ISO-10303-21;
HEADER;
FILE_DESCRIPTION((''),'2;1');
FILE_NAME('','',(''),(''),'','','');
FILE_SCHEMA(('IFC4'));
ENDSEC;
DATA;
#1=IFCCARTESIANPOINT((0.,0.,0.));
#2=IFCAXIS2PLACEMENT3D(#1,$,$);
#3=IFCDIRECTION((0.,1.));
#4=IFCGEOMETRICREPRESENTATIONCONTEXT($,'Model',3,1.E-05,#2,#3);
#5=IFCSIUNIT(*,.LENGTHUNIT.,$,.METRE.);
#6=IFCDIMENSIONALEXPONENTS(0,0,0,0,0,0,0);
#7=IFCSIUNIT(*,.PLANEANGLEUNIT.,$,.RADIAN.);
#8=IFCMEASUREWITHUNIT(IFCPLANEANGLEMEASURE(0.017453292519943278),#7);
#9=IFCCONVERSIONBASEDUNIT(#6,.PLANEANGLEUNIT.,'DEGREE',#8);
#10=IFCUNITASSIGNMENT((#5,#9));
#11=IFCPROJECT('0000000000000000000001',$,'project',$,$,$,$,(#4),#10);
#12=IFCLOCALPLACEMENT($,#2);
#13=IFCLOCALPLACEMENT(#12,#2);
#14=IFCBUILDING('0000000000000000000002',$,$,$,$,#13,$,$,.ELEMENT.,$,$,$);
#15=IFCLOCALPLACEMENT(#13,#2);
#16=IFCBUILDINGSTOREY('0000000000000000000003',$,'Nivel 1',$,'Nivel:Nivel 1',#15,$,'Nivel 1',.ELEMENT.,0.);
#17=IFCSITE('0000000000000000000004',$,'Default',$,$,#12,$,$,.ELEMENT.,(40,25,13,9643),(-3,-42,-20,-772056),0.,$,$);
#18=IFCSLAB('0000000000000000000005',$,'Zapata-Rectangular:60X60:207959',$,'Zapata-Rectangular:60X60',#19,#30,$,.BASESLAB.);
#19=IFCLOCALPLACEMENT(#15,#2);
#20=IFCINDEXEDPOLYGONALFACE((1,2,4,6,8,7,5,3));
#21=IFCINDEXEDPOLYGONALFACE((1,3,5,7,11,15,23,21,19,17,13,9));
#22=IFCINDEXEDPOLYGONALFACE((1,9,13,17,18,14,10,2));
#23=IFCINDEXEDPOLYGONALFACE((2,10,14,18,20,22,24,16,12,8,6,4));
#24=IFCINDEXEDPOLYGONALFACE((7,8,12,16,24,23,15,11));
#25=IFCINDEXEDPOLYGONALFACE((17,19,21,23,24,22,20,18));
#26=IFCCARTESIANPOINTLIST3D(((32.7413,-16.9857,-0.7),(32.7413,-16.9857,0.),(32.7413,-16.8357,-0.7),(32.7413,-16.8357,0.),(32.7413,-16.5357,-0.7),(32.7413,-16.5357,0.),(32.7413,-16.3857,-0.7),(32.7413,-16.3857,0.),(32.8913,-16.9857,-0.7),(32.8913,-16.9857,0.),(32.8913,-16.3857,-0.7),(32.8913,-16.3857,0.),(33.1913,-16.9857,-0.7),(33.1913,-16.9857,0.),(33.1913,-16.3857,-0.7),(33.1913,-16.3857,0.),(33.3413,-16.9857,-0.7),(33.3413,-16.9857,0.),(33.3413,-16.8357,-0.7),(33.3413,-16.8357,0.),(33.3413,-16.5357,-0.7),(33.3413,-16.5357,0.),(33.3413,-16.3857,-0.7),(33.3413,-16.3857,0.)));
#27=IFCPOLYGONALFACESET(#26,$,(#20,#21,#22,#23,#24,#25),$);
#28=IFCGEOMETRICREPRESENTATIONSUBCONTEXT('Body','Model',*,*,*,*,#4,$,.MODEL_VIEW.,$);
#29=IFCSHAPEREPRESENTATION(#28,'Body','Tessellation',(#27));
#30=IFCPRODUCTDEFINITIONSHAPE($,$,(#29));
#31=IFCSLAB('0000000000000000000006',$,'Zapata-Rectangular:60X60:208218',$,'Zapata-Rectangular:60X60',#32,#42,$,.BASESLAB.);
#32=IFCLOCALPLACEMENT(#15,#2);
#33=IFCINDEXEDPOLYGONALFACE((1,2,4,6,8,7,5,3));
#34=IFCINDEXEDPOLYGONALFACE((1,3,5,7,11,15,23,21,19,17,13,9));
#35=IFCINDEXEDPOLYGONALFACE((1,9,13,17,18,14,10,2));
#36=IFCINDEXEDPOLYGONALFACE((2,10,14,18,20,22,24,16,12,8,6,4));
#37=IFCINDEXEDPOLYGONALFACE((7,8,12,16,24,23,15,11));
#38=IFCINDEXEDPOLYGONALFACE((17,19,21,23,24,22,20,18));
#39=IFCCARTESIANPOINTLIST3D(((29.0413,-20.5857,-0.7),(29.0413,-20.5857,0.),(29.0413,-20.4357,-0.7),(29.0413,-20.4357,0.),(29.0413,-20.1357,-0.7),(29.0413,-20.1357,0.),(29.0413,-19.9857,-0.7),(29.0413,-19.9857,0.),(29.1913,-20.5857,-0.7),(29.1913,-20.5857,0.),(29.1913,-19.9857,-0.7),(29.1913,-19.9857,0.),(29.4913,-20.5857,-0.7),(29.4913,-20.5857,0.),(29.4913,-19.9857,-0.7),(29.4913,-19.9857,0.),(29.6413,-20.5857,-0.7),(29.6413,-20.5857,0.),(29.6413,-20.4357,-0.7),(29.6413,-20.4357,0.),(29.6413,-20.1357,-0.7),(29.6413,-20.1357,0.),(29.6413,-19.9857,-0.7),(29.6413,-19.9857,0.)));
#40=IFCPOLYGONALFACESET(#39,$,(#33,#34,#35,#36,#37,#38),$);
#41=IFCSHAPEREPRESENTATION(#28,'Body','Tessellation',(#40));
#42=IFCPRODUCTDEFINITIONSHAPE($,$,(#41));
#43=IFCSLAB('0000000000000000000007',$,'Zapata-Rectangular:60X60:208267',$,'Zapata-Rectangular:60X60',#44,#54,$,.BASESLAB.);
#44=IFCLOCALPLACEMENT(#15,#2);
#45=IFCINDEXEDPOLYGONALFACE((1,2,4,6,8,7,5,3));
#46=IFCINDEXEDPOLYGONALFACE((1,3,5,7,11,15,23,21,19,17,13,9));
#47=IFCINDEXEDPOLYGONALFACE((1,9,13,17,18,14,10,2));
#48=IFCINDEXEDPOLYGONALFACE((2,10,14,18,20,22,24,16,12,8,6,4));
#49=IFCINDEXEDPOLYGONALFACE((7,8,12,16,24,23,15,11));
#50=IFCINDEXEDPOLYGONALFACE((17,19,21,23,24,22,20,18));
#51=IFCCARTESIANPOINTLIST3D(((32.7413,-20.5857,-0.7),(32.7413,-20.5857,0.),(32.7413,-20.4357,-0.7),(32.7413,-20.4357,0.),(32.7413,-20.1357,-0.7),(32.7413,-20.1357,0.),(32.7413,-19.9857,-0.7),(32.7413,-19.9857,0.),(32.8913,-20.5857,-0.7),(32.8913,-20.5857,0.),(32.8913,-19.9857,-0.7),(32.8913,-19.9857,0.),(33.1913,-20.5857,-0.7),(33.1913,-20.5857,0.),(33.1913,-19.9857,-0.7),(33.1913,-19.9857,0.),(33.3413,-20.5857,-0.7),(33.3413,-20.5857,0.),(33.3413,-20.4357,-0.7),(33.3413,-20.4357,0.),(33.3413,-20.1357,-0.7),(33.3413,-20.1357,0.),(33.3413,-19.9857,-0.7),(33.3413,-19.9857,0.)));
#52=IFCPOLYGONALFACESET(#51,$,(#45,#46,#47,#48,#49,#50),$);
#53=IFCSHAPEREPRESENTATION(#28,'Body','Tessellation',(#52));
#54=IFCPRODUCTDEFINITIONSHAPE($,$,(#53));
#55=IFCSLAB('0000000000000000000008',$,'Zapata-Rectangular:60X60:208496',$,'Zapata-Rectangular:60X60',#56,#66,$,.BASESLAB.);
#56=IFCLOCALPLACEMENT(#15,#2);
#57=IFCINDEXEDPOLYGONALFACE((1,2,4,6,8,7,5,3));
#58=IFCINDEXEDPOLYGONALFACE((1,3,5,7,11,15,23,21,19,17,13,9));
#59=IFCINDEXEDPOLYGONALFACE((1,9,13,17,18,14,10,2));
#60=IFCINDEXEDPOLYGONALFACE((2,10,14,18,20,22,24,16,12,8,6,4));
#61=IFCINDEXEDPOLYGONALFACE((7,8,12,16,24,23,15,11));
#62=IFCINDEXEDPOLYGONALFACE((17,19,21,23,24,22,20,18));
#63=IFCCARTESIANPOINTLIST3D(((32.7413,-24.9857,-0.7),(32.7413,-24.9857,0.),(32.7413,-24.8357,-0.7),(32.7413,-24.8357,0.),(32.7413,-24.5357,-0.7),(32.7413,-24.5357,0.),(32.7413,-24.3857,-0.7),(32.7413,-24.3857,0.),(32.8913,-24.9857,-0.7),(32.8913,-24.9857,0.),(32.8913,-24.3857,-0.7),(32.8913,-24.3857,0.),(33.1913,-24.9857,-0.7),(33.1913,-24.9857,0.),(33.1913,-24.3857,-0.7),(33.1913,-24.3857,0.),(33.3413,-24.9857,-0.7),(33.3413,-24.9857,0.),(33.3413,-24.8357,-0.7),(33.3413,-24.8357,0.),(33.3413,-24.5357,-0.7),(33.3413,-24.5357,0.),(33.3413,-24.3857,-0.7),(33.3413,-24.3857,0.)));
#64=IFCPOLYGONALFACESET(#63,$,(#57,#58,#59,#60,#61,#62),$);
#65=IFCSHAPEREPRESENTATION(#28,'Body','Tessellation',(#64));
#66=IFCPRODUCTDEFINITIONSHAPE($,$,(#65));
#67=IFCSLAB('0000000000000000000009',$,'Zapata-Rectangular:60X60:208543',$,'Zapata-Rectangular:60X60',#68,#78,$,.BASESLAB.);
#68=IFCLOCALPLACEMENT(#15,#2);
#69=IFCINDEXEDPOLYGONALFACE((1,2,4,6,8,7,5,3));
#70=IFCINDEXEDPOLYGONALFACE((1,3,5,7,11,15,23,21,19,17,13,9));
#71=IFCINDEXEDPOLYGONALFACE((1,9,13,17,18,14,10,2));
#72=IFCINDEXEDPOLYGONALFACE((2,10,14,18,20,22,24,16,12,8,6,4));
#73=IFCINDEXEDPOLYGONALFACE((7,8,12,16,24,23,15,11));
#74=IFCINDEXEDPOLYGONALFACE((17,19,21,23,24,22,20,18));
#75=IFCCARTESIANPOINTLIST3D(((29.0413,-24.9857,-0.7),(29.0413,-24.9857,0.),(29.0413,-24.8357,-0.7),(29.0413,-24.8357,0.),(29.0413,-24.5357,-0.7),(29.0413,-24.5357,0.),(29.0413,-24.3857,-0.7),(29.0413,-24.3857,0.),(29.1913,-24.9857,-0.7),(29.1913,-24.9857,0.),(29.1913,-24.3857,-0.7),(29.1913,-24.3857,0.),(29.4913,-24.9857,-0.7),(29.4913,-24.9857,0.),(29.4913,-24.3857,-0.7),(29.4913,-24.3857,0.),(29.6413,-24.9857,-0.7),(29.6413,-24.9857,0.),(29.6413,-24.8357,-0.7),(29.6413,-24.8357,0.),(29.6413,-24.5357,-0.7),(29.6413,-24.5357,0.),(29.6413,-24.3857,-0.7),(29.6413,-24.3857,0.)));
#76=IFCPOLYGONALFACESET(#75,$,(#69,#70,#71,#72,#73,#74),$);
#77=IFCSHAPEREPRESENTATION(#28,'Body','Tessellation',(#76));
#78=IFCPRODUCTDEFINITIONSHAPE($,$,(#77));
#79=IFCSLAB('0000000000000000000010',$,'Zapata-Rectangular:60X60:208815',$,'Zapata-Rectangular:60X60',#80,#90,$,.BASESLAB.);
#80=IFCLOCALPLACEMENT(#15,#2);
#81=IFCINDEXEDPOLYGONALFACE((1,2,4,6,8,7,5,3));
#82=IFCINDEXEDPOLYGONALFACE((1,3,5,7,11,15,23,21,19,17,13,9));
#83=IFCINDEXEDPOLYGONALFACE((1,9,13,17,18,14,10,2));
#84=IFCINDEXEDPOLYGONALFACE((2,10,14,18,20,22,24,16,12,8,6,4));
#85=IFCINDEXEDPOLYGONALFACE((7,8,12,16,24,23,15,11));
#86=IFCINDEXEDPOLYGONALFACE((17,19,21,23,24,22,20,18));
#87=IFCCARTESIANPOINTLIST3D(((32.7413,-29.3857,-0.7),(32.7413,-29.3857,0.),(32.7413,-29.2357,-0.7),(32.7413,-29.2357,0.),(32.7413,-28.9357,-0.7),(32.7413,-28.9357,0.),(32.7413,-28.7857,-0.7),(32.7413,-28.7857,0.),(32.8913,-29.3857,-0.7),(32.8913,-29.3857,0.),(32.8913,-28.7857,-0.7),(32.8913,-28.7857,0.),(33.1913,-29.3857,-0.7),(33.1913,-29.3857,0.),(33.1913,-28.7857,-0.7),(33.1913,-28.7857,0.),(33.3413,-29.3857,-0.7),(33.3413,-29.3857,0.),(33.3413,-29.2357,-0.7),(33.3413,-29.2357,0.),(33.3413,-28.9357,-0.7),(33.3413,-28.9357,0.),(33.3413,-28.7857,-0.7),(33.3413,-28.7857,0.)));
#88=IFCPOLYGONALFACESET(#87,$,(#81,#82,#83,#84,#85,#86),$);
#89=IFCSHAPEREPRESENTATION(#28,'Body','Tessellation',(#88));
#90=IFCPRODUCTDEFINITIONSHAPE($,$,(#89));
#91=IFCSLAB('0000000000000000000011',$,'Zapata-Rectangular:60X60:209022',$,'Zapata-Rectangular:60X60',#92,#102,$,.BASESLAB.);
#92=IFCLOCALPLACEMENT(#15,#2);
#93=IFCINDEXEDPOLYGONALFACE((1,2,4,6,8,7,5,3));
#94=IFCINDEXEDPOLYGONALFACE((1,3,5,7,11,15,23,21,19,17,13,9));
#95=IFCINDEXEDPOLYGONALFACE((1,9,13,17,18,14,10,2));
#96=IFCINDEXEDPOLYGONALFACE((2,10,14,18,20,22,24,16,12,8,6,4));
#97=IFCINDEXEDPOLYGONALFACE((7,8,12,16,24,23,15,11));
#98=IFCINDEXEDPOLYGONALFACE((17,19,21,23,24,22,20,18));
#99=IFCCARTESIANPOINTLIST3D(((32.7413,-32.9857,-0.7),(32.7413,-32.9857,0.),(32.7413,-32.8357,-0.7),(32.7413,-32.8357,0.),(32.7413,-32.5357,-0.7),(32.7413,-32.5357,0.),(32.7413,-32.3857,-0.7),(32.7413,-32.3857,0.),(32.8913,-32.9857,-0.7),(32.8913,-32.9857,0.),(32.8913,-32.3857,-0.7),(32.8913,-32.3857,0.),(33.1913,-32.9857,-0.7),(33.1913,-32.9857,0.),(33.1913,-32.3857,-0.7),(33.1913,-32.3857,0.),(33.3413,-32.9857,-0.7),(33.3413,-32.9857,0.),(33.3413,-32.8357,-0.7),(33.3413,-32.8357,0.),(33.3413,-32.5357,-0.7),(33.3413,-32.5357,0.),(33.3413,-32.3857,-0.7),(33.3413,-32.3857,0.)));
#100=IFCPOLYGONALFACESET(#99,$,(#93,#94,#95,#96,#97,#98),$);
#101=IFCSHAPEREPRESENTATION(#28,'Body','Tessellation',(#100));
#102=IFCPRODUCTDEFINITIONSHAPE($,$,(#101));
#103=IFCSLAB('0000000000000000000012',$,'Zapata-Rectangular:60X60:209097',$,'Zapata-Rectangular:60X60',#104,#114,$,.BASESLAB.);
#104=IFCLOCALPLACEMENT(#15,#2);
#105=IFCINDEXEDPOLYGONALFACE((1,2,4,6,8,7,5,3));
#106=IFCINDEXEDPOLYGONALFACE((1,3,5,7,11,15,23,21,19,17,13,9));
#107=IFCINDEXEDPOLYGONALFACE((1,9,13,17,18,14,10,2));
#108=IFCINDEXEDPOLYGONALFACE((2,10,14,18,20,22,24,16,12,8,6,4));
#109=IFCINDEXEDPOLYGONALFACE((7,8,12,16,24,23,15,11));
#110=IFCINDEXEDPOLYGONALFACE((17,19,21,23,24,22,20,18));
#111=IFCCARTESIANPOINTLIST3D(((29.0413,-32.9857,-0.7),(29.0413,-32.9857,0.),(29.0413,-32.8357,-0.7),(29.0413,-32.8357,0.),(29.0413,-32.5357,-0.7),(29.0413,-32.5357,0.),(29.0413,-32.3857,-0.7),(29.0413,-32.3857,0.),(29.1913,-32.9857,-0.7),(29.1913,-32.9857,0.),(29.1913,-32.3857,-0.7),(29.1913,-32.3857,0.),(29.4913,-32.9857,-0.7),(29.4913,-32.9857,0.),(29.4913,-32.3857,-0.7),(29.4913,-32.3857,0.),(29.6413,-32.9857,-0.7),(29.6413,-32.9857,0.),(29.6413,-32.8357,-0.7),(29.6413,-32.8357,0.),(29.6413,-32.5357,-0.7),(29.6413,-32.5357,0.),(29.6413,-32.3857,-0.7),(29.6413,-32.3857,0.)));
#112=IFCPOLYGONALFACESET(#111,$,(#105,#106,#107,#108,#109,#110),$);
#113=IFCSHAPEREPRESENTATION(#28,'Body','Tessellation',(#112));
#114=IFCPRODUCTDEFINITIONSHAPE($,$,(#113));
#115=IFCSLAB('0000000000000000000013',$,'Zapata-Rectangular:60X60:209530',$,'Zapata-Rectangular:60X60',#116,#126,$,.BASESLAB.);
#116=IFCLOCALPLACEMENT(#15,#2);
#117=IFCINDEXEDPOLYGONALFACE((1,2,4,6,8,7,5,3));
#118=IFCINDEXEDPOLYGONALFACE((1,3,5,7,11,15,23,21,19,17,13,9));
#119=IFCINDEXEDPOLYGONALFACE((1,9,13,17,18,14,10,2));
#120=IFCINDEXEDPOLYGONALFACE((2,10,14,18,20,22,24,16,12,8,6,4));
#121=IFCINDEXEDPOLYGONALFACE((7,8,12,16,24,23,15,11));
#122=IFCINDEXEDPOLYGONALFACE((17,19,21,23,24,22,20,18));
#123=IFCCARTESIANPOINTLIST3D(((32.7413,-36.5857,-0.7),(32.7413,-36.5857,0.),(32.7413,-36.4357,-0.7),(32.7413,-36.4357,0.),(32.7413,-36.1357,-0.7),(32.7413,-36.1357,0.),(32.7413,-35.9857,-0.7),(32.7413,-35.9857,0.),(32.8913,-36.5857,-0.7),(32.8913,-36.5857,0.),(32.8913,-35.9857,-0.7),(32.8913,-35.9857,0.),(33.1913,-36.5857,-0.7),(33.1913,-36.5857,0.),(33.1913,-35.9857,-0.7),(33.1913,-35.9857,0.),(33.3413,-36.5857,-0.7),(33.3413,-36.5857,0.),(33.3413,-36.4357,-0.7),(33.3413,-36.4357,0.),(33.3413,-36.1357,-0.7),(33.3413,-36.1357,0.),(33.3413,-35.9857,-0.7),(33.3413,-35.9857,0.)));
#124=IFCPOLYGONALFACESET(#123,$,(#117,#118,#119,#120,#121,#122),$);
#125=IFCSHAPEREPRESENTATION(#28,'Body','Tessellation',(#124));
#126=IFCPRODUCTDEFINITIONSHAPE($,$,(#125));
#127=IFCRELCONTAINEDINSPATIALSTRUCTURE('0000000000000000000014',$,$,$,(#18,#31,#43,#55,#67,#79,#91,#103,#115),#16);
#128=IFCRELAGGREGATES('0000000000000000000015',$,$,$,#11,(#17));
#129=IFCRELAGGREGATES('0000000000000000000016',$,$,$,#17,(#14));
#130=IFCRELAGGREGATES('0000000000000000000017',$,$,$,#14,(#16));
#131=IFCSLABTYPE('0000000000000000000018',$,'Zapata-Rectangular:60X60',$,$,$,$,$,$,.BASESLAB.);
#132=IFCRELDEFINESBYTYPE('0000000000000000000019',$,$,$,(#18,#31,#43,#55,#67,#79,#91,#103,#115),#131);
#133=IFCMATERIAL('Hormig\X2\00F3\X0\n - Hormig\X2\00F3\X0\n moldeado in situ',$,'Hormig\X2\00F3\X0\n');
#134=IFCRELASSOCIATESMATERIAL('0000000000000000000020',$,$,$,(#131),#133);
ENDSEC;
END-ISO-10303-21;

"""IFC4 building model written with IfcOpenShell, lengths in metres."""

from ifc_helpers import new_model, entity, si_unit, converted_unit, direction, frame, origin, place, context, subcontext, project, spatial, indexed_curve, outline, extrude, material, type_object, element, save


model = new_model("IFC4")

# Units and contexts
model_context = context("Model", 3, precision=1e-05, world=origin(), true_north=direction((0.0, 1.0)))
body_context = subcontext(model_context, "Body", "Model", "MODEL_VIEW")
ifc_project = project(units=[si_unit("LENGTHUNIT", "METRE"), converted_unit("PLANEANGLEUNIT", "DEGREE", entity("IfcPlaneAngleMeasure", 0.017453292519943278), si_unit("PLANEANGLEUNIT", "RADIAN"), dimensions=[0, 0, 0, 0, 0, 0, 0])], contexts=[model_context])

# Site, building, storey
site_placement = place(None, origin())
site = spatial("IfcSite", under=ifc_project, at=site_placement, Name="Default", CompositionType="ELEMENT", RefLatitude=(40, 25, 13, 9643), RefLongitude=(-3, -42, -20, -772056), RefElevation=0.0)
building_placement = place(site_placement, origin())
building = spatial("IfcBuilding", under=site, at=building_placement, CompositionType="ELEMENT")
storey_placement = place(building_placement, origin())
storey = spatial("IfcBuildingStorey", under=building, at=storey_placement, Name="Nivel 1", ObjectType="Nivel:Nivel 1", LongName="Nivel 1", CompositionType="ELEMENT", Elevation=0.0)

# Slabs
ifc_material = material(Name="Hormigón - Hormigón moldeado in situ", Category="Hormigón")
slab_type = type_object("IfcSlabType", Name="Zapata-Rectangular:60X60", PredefinedType="BASESLAB", material=ifc_material)
slab_1_placement = place(storey_placement, origin())
element("IfcSlab", 1, at=slab_1_placement, inside=storey, type_object=slab_type, Name="Zapata-Rectangular:60X60:207959", ObjectType="Zapata-Rectangular:60X60", PredefinedType="BASESLAB", context=body_context, shape_type="SweptSolid", body=[
    extrude(outline(indexed_curve([(-0.3, -0.3), (-0.15, -0.3), (0.15, -0.3), (0.3, -0.3), (0.3, -0.15), (0.3, 0.15), (0.3, 0.3), (0.15, 0.3), (-0.15, 0.3), (-0.3, 0.3), (-0.3, 0.15), (-0.3, -0.15), (-0.3, -0.3)], self_intersect=False)), frame((33.0413, -16.6857, -0.7), z_axis=(0.0, 0.0, 1.0), x_axis=(-1.0, 0.0, 0.0)), (0.0, 0.0, 1.0), 0.7),
])
slab_2_placement = place(storey_placement, origin())
element("IfcSlab", 2, at=slab_2_placement, inside=storey, type_object=slab_type, Name="Zapata-Rectangular:60X60:208218", ObjectType="Zapata-Rectangular:60X60", PredefinedType="BASESLAB", context=body_context, shape_type="SweptSolid", body=[
    extrude(outline(indexed_curve([(-0.3, -0.3), (-0.15, -0.3), (0.15, -0.3), (0.3, -0.3), (0.3, -0.15), (0.3, 0.15), (0.3, 0.3), (0.15, 0.3), (-0.15, 0.3), (-0.3, 0.3), (-0.3, 0.15), (-0.3, -0.15), (-0.3, -0.3)], self_intersect=False)), frame((29.3413, -20.2857, -0.7), z_axis=(0.0, 0.0, 1.0), x_axis=(-1.0, 0.0, 0.0)), (0.0, 0.0, 1.0), 0.7),
])
slab_3_placement = place(storey_placement, origin())
element("IfcSlab", 3, at=slab_3_placement, inside=storey, type_object=slab_type, Name="Zapata-Rectangular:60X60:208267", ObjectType="Zapata-Rectangular:60X60", PredefinedType="BASESLAB", context=body_context, shape_type="SweptSolid", body=[
    extrude(outline(indexed_curve([(-0.3, -0.3), (-0.15, -0.3), (0.15, -0.3), (0.3, -0.3), (0.3, -0.15), (0.3, 0.15), (0.3, 0.3), (0.15, 0.3), (-0.15, 0.3), (-0.3, 0.3), (-0.3, 0.15), (-0.3, -0.15), (-0.3, -0.3)], self_intersect=False)), frame((33.0413, -20.2857, -0.7), z_axis=(0.0, 0.0, 1.0), x_axis=(-1.0, 0.0, 0.0)), (0.0, 0.0, 1.0), 0.7),
])
slab_4_placement = place(storey_placement, origin())
element("IfcSlab", 4, at=slab_4_placement, inside=storey, type_object=slab_type, Name="Zapata-Rectangular:60X60:208496", ObjectType="Zapata-Rectangular:60X60", PredefinedType="BASESLAB", context=body_context, shape_type="SweptSolid", body=[
    extrude(outline(indexed_curve([(-0.3, -0.3), (-0.15, -0.3), (0.15, -0.3), (0.3, -0.3), (0.3, -0.15), (0.3, 0.15), (0.3, 0.3), (0.15, 0.3), (-0.15, 0.3), (-0.3, 0.3), (-0.3, 0.15), (-0.3, -0.15), (-0.3, -0.3)], self_intersect=False)), frame((33.0413, -24.6857, -0.7), z_axis=(0.0, 0.0, 1.0), x_axis=(-1.0, 0.0, 0.0)), (0.0, 0.0, 1.0), 0.7),
])
slab_5_placement = place(storey_placement, origin())
element("IfcSlab", 5, at=slab_5_placement, inside=storey, type_object=slab_type, Name="Zapata-Rectangular:60X60:208543", ObjectType="Zapata-Rectangular:60X60", PredefinedType="BASESLAB", context=body_context, shape_type="SweptSolid", body=[
    extrude(outline(indexed_curve([(-0.3, -0.3), (-0.15, -0.3), (0.15, -0.3), (0.3, -0.3), (0.3, -0.15), (0.3, 0.15), (0.3, 0.3), (0.15, 0.3), (-0.15, 0.3), (-0.3, 0.3), (-0.3, 0.15), (-0.3, -0.15), (-0.3, -0.3)], self_intersect=False)), frame((29.3413, -24.6857, -0.7), z_axis=(0.0, 0.0, 1.0), x_axis=(-1.0, 0.0, 0.0)), (0.0, 0.0, 1.0), 0.7),
])
slab_6_placement = place(storey_placement, origin())
element("IfcSlab", 6, at=slab_6_placement, inside=storey, type_object=slab_type, Name="Zapata-Rectangular:60X60:208815", ObjectType="Zapata-Rectangular:60X60", PredefinedType="BASESLAB", context=body_context, shape_type="SweptSolid", body=[
    extrude(outline(indexed_curve([(-0.3, -0.3), (-0.15, -0.3), (0.15, -0.3), (0.3, -0.3), (0.3, -0.15), (0.3, 0.15), (0.3, 0.3), (0.15, 0.3), (-0.15, 0.3), (-0.3, 0.3), (-0.3, 0.15), (-0.3, -0.15), (-0.3, -0.3)], self_intersect=False)), frame((33.0413, -29.0857, -0.7), z_axis=(0.0, 0.0, 1.0), x_axis=(-1.0, 0.0, 0.0)), (0.0, 0.0, 1.0), 0.7),
])
slab_7_placement = place(storey_placement, origin())
element("IfcSlab", 7, at=slab_7_placement, inside=storey, type_object=slab_type, Name="Zapata-Rectangular:60X60:209022", ObjectType="Zapata-Rectangular:60X60", PredefinedType="BASESLAB", context=body_context, shape_type="SweptSolid", body=[
    extrude(outline(indexed_curve([(-0.3, -0.3), (-0.15, -0.3), (0.15, -0.3), (0.3, -0.3), (0.3, -0.15), (0.3, 0.15), (0.3, 0.3), (0.15, 0.3), (-0.15, 0.3), (-0.3, 0.3), (-0.3, 0.15), (-0.3, -0.15), (-0.3, -0.3)], self_intersect=False)), frame((33.0413, -32.6857, -0.7), z_axis=(0.0, 0.0, 1.0), x_axis=(-1.0, 0.0, 0.0)), (0.0, 0.0, 1.0), 0.7),
])
slab_8_placement = place(storey_placement, origin())
element("IfcSlab", 8, at=slab_8_placement, inside=storey, type_object=slab_type, Name="Zapata-Rectangular:60X60:209097", ObjectType="Zapata-Rectangular:60X60", PredefinedType="BASESLAB", context=body_context, shape_type="SweptSolid", body=[
    extrude(outline(indexed_curve([(-0.3, -0.3), (-0.15, -0.3), (0.15, -0.3), (0.3, -0.3), (0.3, -0.15), (0.3, 0.15), (0.3, 0.3), (0.15, 0.3), (-0.15, 0.3), (-0.3, 0.3), (-0.3, 0.15), (-0.3, -0.15), (-0.3, -0.3)], self_intersect=False)), frame((29.3413, -32.6857, -0.7), z_axis=(0.0, 0.0, 1.0), x_axis=(-1.0, 0.0, 0.0)), (0.0, 0.0, 1.0), 0.7),
])
slab_9_placement = place(storey_placement, origin())
element("IfcSlab", 9, at=slab_9_placement, inside=storey, type_object=slab_type, Name="Zapata-Rectangular:60X60:209530", ObjectType="Zapata-Rectangular:60X60", PredefinedType="BASESLAB", context=body_context, shape_type="SweptSolid", body=[
    extrude(outline(indexed_curve([(-0.3, -0.3), (-0.15, -0.3), (0.15, -0.3), (0.3, -0.3), (0.3, -0.15), (0.3, 0.15), (0.3, 0.3), (0.15, 0.3), (-0.15, 0.3), (-0.3, 0.3), (-0.3, 0.15), (-0.3, -0.15), (-0.3, -0.3)], self_intersect=False)), frame((33.0413, -36.2857, -0.7), z_axis=(0.0, 0.0, 1.0), x_axis=(-1.0, 0.0, 0.0)), (0.0, 0.0, 1.0), 0.7),
])

save(model, "model.ifc")
